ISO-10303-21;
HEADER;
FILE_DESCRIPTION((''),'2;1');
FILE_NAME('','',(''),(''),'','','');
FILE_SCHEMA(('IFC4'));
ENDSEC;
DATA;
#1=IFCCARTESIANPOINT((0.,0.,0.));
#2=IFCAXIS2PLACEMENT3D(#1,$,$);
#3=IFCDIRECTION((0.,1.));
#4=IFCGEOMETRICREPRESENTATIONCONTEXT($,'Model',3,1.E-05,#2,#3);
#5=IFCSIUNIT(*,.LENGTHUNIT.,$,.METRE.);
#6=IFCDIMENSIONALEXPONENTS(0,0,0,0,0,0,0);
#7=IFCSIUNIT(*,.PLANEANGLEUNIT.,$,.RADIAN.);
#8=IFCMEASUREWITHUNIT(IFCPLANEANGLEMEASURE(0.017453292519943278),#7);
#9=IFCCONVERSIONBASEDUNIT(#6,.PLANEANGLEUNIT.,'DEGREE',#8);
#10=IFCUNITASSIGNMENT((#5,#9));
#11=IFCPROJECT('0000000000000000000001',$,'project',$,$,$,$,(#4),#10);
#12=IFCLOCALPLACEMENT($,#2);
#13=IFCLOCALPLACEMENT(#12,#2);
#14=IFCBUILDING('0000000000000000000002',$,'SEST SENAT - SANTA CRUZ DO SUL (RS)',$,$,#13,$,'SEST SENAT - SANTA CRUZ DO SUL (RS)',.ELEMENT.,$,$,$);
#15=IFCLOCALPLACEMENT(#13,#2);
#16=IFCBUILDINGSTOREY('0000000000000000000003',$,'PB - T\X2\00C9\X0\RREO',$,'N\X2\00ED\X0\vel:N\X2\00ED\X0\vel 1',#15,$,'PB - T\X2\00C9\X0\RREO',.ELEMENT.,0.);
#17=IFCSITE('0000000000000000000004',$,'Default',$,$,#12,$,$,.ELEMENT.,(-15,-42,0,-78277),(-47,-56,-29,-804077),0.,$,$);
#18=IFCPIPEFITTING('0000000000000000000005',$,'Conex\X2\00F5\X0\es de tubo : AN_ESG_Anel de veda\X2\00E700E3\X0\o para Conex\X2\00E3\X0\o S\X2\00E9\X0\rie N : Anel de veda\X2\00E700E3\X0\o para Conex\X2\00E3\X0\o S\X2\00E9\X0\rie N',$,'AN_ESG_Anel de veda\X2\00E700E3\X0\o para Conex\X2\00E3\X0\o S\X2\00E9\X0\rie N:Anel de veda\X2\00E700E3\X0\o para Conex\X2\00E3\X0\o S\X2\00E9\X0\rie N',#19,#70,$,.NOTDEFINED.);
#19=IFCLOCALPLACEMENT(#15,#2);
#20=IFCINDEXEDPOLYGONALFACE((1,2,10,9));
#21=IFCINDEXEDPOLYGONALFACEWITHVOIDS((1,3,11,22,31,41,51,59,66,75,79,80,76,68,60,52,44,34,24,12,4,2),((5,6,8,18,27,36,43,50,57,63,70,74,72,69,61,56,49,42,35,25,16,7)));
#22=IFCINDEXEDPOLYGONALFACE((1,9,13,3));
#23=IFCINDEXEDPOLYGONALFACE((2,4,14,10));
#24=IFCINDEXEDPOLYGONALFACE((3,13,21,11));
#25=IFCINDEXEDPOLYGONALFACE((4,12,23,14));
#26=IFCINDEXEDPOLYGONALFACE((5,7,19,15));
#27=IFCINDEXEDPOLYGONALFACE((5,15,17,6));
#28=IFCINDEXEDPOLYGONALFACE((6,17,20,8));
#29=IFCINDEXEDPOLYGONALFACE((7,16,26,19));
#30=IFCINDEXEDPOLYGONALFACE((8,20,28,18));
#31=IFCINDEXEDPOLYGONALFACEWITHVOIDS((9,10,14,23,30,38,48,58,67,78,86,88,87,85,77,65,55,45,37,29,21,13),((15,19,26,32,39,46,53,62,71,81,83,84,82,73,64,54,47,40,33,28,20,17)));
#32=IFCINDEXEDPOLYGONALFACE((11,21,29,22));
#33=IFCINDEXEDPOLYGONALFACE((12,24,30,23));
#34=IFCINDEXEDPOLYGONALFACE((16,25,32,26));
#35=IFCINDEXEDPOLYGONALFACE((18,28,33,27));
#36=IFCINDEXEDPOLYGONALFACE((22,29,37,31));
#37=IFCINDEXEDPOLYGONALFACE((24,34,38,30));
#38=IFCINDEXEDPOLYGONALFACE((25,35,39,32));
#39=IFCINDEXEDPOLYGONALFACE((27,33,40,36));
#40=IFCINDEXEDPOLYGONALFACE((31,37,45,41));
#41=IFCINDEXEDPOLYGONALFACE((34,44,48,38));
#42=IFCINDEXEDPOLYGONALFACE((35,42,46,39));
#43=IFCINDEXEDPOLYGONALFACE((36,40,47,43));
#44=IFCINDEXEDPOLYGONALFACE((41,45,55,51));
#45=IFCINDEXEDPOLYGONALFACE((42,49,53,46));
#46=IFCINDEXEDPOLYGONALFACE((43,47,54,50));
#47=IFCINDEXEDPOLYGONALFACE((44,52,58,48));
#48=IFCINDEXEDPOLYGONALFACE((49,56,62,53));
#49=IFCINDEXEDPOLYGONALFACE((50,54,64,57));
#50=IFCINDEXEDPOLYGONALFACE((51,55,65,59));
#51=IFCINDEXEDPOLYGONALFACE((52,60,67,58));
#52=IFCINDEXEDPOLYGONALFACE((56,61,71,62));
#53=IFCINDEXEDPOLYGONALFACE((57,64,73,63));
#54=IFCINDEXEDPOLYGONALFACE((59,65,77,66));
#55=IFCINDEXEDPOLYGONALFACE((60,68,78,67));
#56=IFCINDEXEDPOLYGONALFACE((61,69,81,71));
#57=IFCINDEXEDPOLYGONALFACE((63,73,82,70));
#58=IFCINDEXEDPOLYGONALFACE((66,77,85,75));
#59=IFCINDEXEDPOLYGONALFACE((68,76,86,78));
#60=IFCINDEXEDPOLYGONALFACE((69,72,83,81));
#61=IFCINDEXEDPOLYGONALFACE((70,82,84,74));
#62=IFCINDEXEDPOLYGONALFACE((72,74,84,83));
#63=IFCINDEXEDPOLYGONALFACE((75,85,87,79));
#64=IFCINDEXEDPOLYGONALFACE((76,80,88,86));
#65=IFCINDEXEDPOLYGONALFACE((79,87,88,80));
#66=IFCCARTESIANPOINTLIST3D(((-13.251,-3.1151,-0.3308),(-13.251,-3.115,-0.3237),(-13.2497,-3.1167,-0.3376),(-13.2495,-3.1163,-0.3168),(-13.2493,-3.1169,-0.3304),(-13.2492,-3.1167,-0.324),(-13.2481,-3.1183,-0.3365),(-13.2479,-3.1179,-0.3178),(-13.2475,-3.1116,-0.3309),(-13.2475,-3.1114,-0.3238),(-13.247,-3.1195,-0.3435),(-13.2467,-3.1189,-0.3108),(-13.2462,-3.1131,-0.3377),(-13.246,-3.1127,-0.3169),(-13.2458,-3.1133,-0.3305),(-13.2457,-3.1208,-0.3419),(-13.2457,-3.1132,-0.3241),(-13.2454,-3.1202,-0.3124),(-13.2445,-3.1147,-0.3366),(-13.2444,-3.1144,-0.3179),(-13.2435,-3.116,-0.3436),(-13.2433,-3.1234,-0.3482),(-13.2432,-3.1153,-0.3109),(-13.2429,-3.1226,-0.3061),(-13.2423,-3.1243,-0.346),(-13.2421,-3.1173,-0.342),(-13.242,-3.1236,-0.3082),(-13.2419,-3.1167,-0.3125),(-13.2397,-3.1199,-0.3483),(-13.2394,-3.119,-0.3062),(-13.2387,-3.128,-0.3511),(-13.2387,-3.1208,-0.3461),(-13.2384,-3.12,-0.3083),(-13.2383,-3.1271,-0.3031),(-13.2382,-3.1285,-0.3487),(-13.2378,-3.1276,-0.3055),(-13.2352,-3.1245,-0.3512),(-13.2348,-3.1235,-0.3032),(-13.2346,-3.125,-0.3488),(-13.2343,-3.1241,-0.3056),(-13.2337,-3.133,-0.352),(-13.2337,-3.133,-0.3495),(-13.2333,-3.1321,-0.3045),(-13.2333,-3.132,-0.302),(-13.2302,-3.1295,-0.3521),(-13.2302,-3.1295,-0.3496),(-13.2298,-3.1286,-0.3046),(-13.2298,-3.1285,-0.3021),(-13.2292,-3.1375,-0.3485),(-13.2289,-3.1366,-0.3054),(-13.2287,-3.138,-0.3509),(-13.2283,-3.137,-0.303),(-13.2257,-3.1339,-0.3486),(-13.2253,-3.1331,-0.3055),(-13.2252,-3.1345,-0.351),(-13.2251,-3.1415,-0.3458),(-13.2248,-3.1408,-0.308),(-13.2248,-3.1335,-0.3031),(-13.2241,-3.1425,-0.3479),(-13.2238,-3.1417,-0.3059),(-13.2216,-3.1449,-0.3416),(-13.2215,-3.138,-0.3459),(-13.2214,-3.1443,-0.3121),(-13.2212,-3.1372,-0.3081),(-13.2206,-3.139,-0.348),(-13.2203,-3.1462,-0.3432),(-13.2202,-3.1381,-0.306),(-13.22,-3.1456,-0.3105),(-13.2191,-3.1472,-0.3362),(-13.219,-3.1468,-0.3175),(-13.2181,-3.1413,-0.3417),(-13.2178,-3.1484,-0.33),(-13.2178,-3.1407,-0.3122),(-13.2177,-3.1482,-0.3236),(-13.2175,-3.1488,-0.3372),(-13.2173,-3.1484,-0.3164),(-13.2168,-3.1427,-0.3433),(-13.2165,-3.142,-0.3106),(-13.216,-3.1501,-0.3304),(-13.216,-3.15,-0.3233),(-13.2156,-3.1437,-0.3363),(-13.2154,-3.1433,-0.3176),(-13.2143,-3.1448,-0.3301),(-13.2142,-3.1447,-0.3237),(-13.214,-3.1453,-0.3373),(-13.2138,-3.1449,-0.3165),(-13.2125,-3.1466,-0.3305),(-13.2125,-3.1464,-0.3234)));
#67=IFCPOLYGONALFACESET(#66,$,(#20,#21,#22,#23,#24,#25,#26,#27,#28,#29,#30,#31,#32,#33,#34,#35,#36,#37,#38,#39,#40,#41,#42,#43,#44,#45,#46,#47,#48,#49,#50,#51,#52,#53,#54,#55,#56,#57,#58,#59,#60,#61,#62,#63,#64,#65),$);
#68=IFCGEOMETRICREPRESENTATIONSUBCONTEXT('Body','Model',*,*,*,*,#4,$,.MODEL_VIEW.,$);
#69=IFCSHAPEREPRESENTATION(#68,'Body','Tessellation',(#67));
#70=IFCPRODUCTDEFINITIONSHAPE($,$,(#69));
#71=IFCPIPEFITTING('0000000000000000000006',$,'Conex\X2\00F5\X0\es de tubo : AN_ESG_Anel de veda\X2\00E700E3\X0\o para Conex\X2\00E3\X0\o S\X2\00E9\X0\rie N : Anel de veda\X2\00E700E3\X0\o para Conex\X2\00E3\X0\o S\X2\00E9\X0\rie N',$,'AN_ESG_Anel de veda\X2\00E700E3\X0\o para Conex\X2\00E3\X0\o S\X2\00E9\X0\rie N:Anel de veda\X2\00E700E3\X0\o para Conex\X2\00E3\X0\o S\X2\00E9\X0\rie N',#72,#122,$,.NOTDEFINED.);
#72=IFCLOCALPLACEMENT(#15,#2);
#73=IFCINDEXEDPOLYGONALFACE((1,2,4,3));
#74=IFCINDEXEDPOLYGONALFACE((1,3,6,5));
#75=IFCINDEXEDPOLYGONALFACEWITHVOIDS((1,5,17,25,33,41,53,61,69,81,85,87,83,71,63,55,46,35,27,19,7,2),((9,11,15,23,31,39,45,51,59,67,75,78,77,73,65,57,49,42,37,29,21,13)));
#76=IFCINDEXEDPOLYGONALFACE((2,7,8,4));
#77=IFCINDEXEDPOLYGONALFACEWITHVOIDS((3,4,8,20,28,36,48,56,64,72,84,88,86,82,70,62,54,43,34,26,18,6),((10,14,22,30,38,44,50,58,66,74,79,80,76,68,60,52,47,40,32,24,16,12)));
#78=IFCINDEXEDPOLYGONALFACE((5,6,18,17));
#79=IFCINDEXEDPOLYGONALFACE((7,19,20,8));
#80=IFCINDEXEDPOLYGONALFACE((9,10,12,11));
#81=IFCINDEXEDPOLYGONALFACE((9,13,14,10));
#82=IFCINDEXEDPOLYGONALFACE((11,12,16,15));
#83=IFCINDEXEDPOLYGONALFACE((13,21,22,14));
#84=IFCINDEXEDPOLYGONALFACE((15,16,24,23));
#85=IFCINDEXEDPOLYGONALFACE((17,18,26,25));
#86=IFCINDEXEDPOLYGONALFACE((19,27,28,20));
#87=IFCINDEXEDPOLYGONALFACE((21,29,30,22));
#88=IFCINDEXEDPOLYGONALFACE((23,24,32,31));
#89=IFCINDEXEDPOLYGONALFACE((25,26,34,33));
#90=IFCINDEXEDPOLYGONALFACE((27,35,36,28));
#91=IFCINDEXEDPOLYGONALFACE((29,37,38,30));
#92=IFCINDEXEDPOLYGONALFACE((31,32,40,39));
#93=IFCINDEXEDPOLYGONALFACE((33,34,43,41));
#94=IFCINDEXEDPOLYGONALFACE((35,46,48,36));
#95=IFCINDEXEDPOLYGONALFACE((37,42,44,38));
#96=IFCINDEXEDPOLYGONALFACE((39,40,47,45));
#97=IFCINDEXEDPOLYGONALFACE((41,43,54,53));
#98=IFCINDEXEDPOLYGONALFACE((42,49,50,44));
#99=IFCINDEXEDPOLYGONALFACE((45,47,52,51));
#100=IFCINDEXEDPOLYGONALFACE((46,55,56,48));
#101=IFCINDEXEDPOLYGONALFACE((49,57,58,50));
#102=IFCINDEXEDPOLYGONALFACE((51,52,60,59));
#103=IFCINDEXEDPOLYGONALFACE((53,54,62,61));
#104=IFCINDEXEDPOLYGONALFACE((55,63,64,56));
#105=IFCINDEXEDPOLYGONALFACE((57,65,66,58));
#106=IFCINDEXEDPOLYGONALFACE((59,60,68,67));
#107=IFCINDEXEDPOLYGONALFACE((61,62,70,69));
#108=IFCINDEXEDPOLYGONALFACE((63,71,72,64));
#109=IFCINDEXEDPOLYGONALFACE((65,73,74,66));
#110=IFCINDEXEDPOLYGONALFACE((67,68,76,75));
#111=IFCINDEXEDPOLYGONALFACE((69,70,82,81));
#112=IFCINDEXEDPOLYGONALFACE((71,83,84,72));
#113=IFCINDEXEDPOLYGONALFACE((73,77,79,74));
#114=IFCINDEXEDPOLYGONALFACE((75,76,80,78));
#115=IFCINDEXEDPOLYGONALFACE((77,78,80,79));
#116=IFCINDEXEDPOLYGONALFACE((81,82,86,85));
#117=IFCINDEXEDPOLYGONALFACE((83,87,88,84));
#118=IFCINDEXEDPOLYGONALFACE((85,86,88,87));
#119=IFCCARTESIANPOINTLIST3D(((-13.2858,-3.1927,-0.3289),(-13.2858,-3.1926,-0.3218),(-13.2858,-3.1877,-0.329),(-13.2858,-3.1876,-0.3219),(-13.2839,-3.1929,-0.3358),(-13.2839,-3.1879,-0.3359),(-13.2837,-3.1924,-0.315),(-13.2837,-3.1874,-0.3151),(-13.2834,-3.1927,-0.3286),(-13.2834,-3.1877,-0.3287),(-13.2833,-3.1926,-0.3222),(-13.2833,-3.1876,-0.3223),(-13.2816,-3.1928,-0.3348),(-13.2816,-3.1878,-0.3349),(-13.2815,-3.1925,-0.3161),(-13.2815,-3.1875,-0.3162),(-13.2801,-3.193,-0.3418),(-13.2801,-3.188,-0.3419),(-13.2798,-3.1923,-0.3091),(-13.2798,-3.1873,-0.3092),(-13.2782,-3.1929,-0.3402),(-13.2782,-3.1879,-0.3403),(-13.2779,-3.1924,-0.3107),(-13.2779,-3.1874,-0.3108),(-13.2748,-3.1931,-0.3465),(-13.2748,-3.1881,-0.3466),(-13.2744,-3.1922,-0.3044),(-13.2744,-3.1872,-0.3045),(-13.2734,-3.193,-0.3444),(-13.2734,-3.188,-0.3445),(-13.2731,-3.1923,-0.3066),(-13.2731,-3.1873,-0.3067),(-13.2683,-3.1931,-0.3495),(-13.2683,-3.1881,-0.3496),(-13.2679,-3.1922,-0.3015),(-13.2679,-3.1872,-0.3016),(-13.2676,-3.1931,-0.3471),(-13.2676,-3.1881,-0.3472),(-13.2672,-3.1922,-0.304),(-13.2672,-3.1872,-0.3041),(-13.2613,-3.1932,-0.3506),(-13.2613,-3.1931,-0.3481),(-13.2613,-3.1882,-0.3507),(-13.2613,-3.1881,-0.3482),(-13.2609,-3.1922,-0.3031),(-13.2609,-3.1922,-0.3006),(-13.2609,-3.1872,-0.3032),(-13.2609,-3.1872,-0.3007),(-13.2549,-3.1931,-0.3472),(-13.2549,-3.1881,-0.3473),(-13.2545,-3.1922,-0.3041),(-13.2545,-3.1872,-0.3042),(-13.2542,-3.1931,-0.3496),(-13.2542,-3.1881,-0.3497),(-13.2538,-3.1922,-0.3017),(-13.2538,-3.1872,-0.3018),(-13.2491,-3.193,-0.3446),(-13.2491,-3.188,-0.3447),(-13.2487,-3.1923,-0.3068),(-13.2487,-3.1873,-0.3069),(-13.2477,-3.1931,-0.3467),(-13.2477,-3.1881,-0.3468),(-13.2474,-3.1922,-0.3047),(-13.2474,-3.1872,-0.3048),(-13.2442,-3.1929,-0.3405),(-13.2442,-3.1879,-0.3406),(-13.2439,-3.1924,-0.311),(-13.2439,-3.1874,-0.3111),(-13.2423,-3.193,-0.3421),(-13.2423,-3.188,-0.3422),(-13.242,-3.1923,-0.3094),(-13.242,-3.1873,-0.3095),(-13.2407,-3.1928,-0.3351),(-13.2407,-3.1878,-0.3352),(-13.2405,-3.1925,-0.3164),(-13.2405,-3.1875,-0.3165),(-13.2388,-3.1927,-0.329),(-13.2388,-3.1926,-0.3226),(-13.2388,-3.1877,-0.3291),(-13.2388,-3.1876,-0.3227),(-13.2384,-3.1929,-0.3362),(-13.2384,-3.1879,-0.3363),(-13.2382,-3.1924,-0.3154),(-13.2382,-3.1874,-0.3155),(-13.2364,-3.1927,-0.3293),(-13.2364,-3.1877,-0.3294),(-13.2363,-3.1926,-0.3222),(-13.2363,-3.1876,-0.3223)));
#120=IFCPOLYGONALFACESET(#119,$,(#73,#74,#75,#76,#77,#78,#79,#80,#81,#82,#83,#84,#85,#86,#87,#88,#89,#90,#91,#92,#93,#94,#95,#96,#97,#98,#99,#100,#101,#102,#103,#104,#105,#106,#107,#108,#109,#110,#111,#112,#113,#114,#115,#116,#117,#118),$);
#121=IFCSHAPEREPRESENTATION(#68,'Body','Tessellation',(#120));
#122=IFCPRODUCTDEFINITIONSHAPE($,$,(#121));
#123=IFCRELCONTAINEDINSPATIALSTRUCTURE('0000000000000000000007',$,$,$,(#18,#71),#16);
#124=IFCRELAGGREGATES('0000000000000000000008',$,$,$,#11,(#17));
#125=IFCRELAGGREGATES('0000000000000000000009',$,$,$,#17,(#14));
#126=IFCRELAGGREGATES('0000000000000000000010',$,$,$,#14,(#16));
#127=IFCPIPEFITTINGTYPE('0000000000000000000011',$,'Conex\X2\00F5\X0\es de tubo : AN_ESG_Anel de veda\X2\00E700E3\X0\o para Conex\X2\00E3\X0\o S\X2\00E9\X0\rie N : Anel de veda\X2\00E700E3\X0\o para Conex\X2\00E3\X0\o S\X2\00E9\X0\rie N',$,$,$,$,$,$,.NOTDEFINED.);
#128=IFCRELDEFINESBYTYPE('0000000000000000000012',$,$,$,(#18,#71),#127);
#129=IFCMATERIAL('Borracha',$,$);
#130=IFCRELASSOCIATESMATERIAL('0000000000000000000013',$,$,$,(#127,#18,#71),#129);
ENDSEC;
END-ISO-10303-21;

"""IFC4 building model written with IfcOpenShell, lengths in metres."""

from ifc_helpers import new_model, entity, si_unit, converted_unit, direction, frame, origin, place, context, subcontext, project, spatial, arc, indexed_curve, outline, extrude, source, transform, mapped, material, type_object, type_shapes, element, save


model = new_model("IFC4")

# Units and contexts
model_context = context("Model", 3, precision=1e-05, world=origin(), true_north=direction((0.0, 1.0)))
body_context = subcontext(model_context, "Body", "Model", "MODEL_VIEW")
ifc_project = project(units=[si_unit("LENGTHUNIT", "METRE"), converted_unit("PLANEANGLEUNIT", "DEGREE", entity("IfcPlaneAngleMeasure", 0.017453292519943278), si_unit("PLANEANGLEUNIT", "RADIAN"), dimensions=[0, 0, 0, 0, 0, 0, 0])], contexts=[model_context])

# Site, building, storey
site_placement = place(None, origin())
site = spatial("IfcSite", under=ifc_project, at=site_placement, Name="Default", CompositionType="ELEMENT", RefLatitude=(-15, -42, 0, -78277), RefLongitude=(-47, -56, -29, -804077), RefElevation=0.0)
building_placement = place(site_placement, origin())
building = spatial("IfcBuilding", under=site, at=building_placement, Name="SEST SENAT - SANTA CRUZ DO SUL (RS)", LongName="SEST SENAT - SANTA CRUZ DO SUL (RS)", CompositionType="ELEMENT")
storey_placement = place(building_placement, origin())
storey = spatial("IfcBuildingStorey", under=building, at=storey_placement, Name="PB - TÉRREO", ObjectType="Nível:Nível 1", LongName="PB - TÉRREO", CompositionType="ELEMENT", Elevation=0.0)

# Pipe fittings
ifc_material_1 = material(Name="Borracha")
pipe_fitting_type_1 = type_object("IfcPipeFittingType", Name="Conexões de tubo : AN_ESG_Anel de vedação para Conexão Série N : Anel de vedação para Conexão Série N", PredefinedType="NOTDEFINED", material=ifc_material_1)
shared_shape_1 = source(origin(), body_context, "Body", "SweptSolid", [
    extrude(outline(indexed_curve([(-0.025, 0.0), (0.0, -0.025), (0.025, 0.0), (0.0, 0.025)], segments=[arc(1, 2, 3), arc(3, 4, 1)], self_intersect=False), holes=[indexed_curve([(-0.0225, 0.0), (0.0, 0.0225), (0.0225, 0.0), (0.0, -0.0225)], segments=[arc(1, 2, 3), arc(3, 4, 1)], self_intersect=False)]), frame((0.0, 0.0, -0.005)), (0.0, 0.0, 1.0), 0.005),
])
type_shapes(pipe_fitting_type_1, [shared_shape_1])
for number, where, z_axis, x_axis, name in (
    (1, (-13.23, -3.129, -0.3271), (0.706965, 0.706965, -0.019996), (0.008282, 0.019995, 0.999766), "Conexões de tubo : AN_ESG_Anel de vedação para Conexão Série N : Anel de vedação para Conexão Série N"),
    (2, (-13.2611, -3.1877, -0.3257), (0.0, 0.9998, -0.019996), (0.008282, 0.019995, 0.999766), "Conexões de tubo : AN_ESG_Anel de vedação para Conexão Série N : Anel de vedação para Conexão Série N"),
):
    element("IfcPipeFitting", number, at=place(storey_placement, frame(where, z_axis=z_axis, x_axis=x_axis)), inside=storey, type_object=pipe_fitting_type_1, material=ifc_material_1, Name=name, ObjectType="AN_ESG_Anel de vedação para Conexão Série N:Anel de vedação para Conexão Série N", PredefinedType="NOTDEFINED", context=body_context, shape_type="MappedRepresentation", body=[
        mapped(shared_shape_1, transform((0.0, 0.0, 0.0), scale=1.0)),
    ])

save(model, "model.ifc")
